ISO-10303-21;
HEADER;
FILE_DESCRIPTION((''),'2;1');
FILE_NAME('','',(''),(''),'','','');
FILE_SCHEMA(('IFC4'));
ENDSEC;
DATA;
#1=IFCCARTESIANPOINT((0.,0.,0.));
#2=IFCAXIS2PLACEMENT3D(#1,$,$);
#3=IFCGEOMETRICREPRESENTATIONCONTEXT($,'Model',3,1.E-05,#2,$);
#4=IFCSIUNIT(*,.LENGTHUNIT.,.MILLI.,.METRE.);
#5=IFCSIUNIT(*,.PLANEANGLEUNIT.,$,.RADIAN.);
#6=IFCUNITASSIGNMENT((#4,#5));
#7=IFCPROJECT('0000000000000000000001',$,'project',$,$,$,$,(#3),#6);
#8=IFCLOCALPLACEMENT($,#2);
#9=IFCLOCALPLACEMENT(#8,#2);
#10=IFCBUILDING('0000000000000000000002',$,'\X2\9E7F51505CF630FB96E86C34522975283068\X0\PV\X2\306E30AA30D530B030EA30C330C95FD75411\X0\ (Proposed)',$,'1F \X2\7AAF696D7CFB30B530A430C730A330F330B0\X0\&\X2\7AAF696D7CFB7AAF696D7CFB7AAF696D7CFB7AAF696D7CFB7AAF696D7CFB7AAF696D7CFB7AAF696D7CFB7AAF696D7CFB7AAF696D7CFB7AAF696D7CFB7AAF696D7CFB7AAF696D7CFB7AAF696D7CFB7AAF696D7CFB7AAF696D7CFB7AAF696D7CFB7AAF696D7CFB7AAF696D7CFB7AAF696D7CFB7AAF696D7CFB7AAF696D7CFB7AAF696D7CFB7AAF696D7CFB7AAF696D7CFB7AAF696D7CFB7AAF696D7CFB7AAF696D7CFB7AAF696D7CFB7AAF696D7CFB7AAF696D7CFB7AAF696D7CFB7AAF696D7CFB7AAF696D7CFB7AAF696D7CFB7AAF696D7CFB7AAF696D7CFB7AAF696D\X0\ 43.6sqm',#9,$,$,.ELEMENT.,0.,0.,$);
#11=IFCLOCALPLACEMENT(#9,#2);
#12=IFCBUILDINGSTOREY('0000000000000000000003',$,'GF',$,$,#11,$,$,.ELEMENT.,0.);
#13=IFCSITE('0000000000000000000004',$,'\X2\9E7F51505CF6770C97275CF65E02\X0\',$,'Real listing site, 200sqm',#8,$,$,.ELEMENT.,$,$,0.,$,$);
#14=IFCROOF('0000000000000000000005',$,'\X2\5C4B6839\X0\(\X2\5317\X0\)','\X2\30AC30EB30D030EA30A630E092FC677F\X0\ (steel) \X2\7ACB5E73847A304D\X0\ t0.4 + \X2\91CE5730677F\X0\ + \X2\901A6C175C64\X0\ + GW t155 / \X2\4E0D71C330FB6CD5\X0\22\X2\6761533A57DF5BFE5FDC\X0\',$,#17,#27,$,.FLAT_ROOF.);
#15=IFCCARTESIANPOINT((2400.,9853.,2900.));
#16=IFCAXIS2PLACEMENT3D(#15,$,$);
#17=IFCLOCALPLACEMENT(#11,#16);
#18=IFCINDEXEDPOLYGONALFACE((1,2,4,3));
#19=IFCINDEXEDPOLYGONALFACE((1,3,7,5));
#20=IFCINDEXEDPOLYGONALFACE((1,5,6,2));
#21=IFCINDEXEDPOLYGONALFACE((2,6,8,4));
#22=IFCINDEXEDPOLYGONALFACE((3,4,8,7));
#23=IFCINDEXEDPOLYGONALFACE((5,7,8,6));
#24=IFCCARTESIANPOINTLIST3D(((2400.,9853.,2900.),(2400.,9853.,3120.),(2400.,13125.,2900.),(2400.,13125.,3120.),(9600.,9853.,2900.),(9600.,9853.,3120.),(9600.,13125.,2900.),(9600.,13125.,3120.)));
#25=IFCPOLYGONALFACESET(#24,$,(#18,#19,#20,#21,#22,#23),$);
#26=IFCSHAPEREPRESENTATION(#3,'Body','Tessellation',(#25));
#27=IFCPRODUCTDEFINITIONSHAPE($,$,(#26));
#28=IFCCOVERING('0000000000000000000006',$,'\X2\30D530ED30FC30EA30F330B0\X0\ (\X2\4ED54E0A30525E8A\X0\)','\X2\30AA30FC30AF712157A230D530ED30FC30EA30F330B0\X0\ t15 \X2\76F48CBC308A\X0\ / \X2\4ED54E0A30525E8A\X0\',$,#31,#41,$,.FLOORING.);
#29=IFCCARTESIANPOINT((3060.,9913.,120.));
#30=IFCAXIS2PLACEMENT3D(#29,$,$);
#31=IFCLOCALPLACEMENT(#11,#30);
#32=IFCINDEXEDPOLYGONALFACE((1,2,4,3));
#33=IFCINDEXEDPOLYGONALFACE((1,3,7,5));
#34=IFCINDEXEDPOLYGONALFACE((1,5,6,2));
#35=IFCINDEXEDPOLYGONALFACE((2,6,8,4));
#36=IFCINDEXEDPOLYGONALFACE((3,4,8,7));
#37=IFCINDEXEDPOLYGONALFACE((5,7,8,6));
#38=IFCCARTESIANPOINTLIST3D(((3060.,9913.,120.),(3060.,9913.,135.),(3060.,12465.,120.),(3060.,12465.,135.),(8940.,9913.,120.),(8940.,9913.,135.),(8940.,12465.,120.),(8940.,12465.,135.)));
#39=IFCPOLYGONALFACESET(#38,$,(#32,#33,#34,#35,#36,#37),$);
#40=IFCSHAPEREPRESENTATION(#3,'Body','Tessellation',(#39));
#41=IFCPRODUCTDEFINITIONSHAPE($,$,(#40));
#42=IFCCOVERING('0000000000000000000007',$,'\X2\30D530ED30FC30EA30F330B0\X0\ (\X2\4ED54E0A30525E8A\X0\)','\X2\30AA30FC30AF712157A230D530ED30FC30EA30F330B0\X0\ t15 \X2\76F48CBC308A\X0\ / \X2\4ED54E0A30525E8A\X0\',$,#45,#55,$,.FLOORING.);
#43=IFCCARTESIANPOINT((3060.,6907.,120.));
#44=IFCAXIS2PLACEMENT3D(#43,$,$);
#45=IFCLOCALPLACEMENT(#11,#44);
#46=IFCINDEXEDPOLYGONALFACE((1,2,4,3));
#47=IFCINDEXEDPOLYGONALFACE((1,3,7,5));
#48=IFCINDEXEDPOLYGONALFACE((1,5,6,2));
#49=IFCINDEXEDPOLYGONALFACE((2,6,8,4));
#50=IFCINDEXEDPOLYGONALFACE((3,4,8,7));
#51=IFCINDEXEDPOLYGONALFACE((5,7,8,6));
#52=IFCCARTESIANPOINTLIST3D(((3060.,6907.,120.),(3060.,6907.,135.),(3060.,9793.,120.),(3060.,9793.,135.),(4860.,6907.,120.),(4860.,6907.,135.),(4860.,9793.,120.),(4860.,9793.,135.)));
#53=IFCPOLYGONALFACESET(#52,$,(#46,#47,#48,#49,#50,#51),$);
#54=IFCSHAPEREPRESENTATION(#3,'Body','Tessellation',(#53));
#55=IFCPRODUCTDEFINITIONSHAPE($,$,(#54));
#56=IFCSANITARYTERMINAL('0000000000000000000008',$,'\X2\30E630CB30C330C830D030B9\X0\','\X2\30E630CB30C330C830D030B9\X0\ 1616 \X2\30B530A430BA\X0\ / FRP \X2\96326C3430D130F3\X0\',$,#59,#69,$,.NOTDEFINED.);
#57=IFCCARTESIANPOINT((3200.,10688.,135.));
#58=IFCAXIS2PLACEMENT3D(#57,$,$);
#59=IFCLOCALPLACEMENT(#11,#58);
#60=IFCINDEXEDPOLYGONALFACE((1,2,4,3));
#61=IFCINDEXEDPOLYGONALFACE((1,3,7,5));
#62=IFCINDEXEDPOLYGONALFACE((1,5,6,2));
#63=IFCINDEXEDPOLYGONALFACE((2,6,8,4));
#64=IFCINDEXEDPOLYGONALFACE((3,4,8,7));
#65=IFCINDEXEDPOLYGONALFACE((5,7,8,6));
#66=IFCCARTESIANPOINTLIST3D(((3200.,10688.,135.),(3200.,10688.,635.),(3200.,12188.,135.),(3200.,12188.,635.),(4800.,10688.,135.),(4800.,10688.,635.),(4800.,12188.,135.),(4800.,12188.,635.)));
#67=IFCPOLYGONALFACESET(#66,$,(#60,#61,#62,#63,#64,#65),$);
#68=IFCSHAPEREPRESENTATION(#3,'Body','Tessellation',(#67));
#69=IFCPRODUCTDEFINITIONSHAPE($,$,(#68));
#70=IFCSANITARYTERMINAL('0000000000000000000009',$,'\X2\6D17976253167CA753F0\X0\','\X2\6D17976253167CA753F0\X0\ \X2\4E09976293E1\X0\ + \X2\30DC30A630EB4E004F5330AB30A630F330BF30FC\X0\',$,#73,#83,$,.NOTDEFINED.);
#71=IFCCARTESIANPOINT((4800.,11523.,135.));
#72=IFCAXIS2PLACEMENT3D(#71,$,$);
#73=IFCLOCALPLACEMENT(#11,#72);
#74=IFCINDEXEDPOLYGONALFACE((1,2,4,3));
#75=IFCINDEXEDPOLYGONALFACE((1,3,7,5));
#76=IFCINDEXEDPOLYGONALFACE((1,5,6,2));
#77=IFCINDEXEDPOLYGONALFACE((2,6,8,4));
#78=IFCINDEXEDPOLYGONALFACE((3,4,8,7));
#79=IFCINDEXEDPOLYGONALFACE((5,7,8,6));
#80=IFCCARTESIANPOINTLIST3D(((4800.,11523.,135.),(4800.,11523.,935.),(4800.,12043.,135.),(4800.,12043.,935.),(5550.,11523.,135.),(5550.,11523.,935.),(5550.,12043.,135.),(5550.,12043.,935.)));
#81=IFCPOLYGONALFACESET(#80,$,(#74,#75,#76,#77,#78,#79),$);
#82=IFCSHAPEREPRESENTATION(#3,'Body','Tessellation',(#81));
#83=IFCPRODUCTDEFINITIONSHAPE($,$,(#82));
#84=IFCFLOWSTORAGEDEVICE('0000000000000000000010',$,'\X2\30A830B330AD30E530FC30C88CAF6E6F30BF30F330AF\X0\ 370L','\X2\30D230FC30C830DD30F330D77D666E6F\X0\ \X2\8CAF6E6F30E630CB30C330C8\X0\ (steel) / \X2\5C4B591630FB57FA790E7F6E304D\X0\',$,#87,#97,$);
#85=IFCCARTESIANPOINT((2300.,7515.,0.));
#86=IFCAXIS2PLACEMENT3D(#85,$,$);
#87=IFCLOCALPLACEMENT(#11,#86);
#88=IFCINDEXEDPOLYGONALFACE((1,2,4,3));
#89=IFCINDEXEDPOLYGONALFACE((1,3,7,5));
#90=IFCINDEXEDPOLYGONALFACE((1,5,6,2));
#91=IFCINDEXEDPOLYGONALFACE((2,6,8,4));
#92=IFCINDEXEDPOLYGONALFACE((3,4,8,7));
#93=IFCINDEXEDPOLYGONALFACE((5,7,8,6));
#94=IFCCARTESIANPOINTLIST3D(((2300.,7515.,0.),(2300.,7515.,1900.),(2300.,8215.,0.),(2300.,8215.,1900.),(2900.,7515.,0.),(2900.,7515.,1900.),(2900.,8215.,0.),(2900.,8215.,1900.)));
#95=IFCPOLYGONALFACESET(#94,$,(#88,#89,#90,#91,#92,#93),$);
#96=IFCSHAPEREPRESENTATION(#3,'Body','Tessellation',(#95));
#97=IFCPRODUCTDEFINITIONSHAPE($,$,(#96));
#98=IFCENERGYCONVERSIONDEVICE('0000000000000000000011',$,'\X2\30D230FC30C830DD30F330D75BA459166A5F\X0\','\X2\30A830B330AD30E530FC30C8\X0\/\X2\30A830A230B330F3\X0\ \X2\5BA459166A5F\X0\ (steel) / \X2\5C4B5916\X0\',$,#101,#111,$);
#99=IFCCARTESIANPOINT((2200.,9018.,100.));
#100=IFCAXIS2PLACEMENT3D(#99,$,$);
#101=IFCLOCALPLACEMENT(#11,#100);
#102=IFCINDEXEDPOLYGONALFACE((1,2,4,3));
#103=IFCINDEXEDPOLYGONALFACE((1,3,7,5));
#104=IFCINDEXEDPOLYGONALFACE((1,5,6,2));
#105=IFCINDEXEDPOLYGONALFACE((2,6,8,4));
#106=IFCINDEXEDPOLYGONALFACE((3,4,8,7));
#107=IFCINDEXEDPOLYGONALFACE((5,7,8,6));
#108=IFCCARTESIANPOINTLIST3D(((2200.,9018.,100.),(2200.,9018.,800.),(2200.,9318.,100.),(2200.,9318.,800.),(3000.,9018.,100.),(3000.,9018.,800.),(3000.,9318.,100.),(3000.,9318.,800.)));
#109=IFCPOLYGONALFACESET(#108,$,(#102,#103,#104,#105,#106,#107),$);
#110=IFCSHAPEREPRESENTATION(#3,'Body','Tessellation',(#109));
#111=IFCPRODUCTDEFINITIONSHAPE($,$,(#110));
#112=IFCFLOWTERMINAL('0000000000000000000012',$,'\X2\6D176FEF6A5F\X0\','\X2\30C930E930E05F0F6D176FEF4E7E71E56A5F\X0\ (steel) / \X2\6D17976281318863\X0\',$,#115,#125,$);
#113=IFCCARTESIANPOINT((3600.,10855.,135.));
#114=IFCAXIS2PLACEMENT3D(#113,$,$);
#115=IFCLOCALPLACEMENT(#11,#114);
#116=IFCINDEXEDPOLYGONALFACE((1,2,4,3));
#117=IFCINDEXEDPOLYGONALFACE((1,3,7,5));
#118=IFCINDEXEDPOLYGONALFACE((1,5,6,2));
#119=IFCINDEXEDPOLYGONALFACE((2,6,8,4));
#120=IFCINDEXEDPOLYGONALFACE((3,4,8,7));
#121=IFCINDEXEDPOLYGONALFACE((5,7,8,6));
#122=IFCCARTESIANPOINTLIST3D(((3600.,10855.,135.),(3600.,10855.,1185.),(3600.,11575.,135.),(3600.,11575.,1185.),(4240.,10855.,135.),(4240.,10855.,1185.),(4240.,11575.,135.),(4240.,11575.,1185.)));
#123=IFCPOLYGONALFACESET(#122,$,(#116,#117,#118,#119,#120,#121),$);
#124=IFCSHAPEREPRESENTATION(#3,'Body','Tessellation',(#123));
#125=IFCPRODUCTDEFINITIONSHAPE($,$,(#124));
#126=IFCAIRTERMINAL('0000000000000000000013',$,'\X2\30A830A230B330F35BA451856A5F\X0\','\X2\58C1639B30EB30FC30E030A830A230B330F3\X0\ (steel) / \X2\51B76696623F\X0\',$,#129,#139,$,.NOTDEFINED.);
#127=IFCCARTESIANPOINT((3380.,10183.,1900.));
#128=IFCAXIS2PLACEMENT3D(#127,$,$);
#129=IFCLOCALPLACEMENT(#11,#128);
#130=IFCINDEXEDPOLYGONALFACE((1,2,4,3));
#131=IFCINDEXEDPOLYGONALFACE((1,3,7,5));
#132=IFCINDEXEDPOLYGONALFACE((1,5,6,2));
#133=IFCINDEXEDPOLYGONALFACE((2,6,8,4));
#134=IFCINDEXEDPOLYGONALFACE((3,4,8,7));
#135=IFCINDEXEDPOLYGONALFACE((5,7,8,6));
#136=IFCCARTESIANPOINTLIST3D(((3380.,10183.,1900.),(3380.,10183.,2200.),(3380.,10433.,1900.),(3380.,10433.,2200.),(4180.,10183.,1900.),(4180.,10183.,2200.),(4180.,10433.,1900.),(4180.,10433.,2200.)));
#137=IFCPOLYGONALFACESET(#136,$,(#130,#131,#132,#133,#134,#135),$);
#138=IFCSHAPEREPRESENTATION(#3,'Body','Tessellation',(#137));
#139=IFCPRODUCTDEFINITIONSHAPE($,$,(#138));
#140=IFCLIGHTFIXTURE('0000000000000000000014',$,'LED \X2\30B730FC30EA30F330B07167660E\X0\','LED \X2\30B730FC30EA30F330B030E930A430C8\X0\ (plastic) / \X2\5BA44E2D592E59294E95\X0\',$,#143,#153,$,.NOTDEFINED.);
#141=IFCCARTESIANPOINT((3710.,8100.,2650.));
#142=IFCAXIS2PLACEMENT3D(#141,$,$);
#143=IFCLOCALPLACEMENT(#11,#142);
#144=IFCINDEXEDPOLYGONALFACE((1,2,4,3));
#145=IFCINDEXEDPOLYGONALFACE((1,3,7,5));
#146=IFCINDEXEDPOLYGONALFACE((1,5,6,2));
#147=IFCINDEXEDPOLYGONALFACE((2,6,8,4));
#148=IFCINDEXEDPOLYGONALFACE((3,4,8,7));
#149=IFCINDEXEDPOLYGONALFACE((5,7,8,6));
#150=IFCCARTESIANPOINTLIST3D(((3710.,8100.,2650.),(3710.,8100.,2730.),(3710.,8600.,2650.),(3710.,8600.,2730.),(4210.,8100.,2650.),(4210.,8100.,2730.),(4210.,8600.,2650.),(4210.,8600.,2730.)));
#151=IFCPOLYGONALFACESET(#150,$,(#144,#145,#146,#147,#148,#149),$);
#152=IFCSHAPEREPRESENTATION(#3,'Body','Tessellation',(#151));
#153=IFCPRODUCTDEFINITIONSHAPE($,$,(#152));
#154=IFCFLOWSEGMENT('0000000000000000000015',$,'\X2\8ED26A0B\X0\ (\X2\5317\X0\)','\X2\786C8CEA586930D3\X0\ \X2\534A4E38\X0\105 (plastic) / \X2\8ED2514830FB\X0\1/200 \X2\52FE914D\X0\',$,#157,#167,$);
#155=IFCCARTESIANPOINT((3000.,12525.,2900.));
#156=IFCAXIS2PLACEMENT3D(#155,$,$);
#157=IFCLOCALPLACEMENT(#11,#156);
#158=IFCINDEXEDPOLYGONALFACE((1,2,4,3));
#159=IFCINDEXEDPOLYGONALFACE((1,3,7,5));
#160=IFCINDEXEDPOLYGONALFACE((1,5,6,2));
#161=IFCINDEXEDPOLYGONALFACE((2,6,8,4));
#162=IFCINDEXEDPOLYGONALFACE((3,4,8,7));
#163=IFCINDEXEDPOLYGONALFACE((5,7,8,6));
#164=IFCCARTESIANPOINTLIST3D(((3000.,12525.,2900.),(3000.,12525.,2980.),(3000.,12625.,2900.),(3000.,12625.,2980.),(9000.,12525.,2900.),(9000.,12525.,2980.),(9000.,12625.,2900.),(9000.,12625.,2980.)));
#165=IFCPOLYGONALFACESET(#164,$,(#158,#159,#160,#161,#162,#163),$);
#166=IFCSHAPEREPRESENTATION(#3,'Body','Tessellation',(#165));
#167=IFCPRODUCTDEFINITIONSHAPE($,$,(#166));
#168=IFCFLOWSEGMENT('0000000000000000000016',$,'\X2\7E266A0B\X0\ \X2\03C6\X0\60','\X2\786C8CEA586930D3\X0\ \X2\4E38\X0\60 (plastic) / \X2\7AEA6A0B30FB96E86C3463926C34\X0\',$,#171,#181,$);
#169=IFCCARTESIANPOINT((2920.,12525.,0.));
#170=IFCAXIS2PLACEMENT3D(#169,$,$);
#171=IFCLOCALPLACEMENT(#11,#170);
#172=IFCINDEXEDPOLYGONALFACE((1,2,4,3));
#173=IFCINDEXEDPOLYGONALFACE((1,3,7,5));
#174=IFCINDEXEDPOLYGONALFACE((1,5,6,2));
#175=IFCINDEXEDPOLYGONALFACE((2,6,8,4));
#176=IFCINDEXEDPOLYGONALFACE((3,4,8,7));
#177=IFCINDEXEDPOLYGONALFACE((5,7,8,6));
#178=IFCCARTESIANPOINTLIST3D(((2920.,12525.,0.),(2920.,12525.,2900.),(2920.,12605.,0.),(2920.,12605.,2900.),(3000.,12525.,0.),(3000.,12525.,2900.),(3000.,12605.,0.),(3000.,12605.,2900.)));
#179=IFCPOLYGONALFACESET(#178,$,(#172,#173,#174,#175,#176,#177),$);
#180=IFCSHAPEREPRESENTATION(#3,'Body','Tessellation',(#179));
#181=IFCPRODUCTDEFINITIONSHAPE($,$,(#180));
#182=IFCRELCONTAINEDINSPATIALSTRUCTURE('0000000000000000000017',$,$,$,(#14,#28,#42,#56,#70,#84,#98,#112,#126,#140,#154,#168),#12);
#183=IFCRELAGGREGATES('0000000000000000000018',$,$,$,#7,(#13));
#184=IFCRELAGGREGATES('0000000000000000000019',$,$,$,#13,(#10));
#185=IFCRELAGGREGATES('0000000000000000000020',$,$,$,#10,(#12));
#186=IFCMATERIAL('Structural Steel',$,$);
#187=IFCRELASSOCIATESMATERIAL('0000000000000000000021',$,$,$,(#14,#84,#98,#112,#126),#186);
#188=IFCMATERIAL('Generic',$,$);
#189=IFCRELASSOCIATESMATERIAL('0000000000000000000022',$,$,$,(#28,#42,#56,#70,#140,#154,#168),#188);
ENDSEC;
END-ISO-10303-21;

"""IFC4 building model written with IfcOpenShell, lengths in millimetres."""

from ifc_helpers import new_model, si_unit, frame, frame_2d, origin, place, context, project, spatial, rectangle, extrude, material, element, save


model = new_model("IFC4")

# Units and contexts
model_context = context("Model", 3, precision=1e-05, world=origin())
ifc_project = project(units=[si_unit("LENGTHUNIT", "METRE", prefix="MILLI"), si_unit("PLANEANGLEUNIT", "RADIAN")], contexts=[model_context])

# Site, building, storey
site_placement = place(None, origin())
site = spatial("IfcSite", under=ifc_project, at=site_placement, Name="鹿児島県霧島市", ObjectType="Real listing site, 200sqm", CompositionType="ELEMENT", RefElevation=0.0)
building_placement = place(site_placement, origin())
building = spatial("IfcBuilding", under=site, at=building_placement, Name="鹿児島・雨水利用とPVのオフグリッド志向 (Proposed)", ObjectType="1F 窯業系サイディング&窯業系窯業系窯業系窯業系窯業系窯業系窯業系窯業系窯業系窯業系窯業系窯業系窯業系窯業系窯業系窯業系窯業系窯業系窯業系窯業系窯業系窯業系窯業系窯業系窯業系窯業系窯業系窯業系窯業系窯業系窯業系窯業系窯業系窯業系窯業系窯業系窯業 43.6sqm", CompositionType="ELEMENT", ElevationOfRefHeight=0.0, ElevationOfTerrain=0.0)
storey_placement = place(building_placement, origin())
storey = spatial("IfcBuildingStorey", under=building, at=storey_placement, Name="GF", CompositionType="ELEMENT", Elevation=0.0)

# Roof
ifc_material_1 = material(Name="Structural Steel")
roof_placement = place(storey_placement, frame((2400.0, 9853.0, 2900.0)))
element("IfcRoof", 1, at=roof_placement, inside=storey, material=ifc_material_1, Name="屋根(北)", Description="ガルバリウム鋼板 (steel) 立平葺き t0.4 + 野地板 + 通気層 + GW t155 / 不燃・法22条区域対応", PredefinedType="FLAT_ROOF", context=model_context, shape_type="SweptSolid", body=[
    extrude(rectangle(XDim=7200.0, YDim=3272.0, at=frame_2d((3600.0, 1636.0))), frame((2400.0, 9853.0, 2900.0)), (0.0, 0.0, 1.0), 220.0),
])

# Coverings
ifc_material_2 = material(Name="Generic")
covering_1_placement = place(storey_placement, frame((3060.0, 9913.0, 120.0)))
element("IfcCovering", 2, at=covering_1_placement, inside=storey, material=ifc_material_2, Name="フローリング (仕上げ床)", Description="オーク無垢フローリング t15 直貼り / 仕上げ床", PredefinedType="FLOORING", context=model_context, shape_type="SweptSolid", body=[
    extrude(rectangle(XDim=5880.0, YDim=2552.0, at=frame_2d((2940.0, 1276.0))), frame((3060.0, 9913.0, 120.0)), (0.0, 0.0, 1.0), 15.0),
])
covering_2_placement = place(storey_placement, frame((3060.0, 6907.0, 120.0)))
element("IfcCovering", 3, at=covering_2_placement, inside=storey, material=ifc_material_2, Name="フローリング (仕上げ床)", Description="オーク無垢フローリング t15 直貼り / 仕上げ床", PredefinedType="FLOORING", context=model_context, shape_type="SweptSolid", body=[
    extrude(rectangle(XDim=1800.0, YDim=2886.0, at=frame_2d((900.0, 1443.0))), frame((3060.0, 6907.0, 120.0)), (0.0, 0.0, 1.0), 15.0),
])

# Sanitary terminals
sanitary_terminal_1_placement = place(storey_placement, frame((3200.0, 10688.0, 135.0)))
element("IfcSanitaryTerminal", 4, at=sanitary_terminal_1_placement, inside=storey, material=ifc_material_2, Name="ユニットバス", Description="ユニットバス 1616 サイズ / FRP 防水パン", PredefinedType="NOTDEFINED", context=model_context, shape_type="SweptSolid", body=[
    extrude(rectangle(XDim=1600.0, YDim=1500.0, at=frame_2d((800.0, 750.0))), frame((3200.0, 10688.0, 135.0)), (0.0, 0.0, 1.0), 500.0),
])
sanitary_terminal_2_placement = place(storey_placement, frame((4800.0, 11523.0, 135.0)))
element("IfcSanitaryTerminal", 5, at=sanitary_terminal_2_placement, inside=storey, material=ifc_material_2, Name="洗面化粧台", Description="洗面化粧台 三面鏡 + ボウル一体カウンター", PredefinedType="NOTDEFINED", context=model_context, shape_type="SweptSolid", body=[
    extrude(rectangle(XDim=750.0, YDim=520.0, at=frame_2d((375.0, 260.0))), frame((4800.0, 11523.0, 135.0)), (0.0, 0.0, 1.0), 800.0),
])

# Flow storage device
flow_storage_device_placement = place(storey_placement, frame((2300.0, 7515.0, 0.0)))
element("IfcFlowStorageDevice", 6, at=flow_storage_device_placement, inside=storey, material=ifc_material_1, Name="エコキュート貯湯タンク 370L", Description="ヒートポンプ給湯 貯湯ユニット (steel) / 屋外・基礎置き", context=model_context, shape_type="SweptSolid", body=[
    extrude(rectangle(XDim=600.0, YDim=700.0, at=frame_2d((300.0, 350.0))), frame((2300.0, 7515.0, 0.0)), (0.0, 0.0, 1.0), 1900.0),
])

# Energy conversion device
energy_conversion_device_placement = place(storey_placement, frame((2200.0, 9018.0, 100.0)))
element("IfcEnergyConversionDevice", 7, at=energy_conversion_device_placement, inside=storey, material=ifc_material_1, Name="ヒートポンプ室外機", Description="エコキュート/エアコン 室外機 (steel) / 屋外", context=model_context, shape_type="SweptSolid", body=[
    extrude(rectangle(XDim=800.0, YDim=300.0, at=frame_2d((400.0, 150.0))), frame((2200.0, 9018.0, 100.0)), (0.0, 0.0, 1.0), 700.0),
])

# Flow terminal
flow_terminal_placement = place(storey_placement, frame((3600.0, 10855.0, 135.0)))
element("IfcFlowTerminal", 8, at=flow_terminal_placement, inside=storey, material=ifc_material_1, Name="洗濯機", Description="ドラム式洗濯乾燥機 (steel) / 洗面脱衣", context=model_context, shape_type="SweptSolid", body=[
    extrude(rectangle(XDim=640.0, YDim=720.0, at=frame_2d((320.0, 360.0))), frame((3600.0, 10855.0, 135.0)), (0.0, 0.0, 1.0), 1050.0),
])

# Air terminal
air_terminal_placement = place(storey_placement, frame((3380.0, 10183.0, 1900.0)))
element("IfcAirTerminal", 9, at=air_terminal_placement, inside=storey, material=ifc_material_1, Name="エアコン室内機", Description="壁掛ルームエアコン (steel) / 冷暖房", PredefinedType="NOTDEFINED", context=model_context, shape_type="SweptSolid", body=[
    extrude(rectangle(XDim=800.0, YDim=250.0, at=frame_2d((400.0, 125.0))), frame((3380.0, 10183.0, 1900.0)), (0.0, 0.0, 1.0), 300.0),
])

# Light fixture
light_fixture_placement = place(storey_placement, frame((3710.0, 8100.0, 2650.0)))
element("IfcLightFixture", 10, at=light_fixture_placement, inside=storey, material=ifc_material_2, Name="LED シーリング照明", Description="LED シーリングライト (plastic) / 室中央天井", PredefinedType="NOTDEFINED", context=model_context, shape_type="SweptSolid", body=[
    extrude(rectangle(XDim=500.0, YDim=500.0, at=frame_2d((250.0, 250.0))), frame((3710.0, 8100.0, 2650.0)), (0.0, 0.0, 1.0), 80.0),
])

# Flow segments
flow_segment_1_placement = place(storey_placement, frame((3000.0, 12525.0, 2900.0)))
element("IfcFlowSegment", 11, at=flow_segment_1_placement, inside=storey, material=ifc_material_2, Name="軒樋 (北)", Description="硬質塩ビ 半丸105 (plastic) / 軒先・1/200 勾配", context=model_context, shape_type="SweptSolid", body=[
    extrude(rectangle(XDim=6000.0, YDim=100.0, at=frame_2d((3000.0, 50.0))), frame((3000.0, 12525.0, 2900.0)), (0.0, 0.0, 1.0), 80.0),
])
flow_segment_2_placement = place(storey_placement, frame((2920.0, 12525.0, 0.0)))
element("IfcFlowSegment", 12, at=flow_segment_2_placement, inside=storey, material=ifc_material_2, Name="縦樋 φ60", Description="硬質塩ビ 丸60 (plastic) / 竪樋・雨水排水", context=model_context, shape_type="SweptSolid", body=[
    extrude(rectangle(XDim=80.0, YDim=80.0, at=frame_2d((40.0, 40.0))), frame((2920.0, 12525.0, 0.0)), (0.0, 0.0, 1.0), 2900.0),
])

save(model, "model.ifc")
